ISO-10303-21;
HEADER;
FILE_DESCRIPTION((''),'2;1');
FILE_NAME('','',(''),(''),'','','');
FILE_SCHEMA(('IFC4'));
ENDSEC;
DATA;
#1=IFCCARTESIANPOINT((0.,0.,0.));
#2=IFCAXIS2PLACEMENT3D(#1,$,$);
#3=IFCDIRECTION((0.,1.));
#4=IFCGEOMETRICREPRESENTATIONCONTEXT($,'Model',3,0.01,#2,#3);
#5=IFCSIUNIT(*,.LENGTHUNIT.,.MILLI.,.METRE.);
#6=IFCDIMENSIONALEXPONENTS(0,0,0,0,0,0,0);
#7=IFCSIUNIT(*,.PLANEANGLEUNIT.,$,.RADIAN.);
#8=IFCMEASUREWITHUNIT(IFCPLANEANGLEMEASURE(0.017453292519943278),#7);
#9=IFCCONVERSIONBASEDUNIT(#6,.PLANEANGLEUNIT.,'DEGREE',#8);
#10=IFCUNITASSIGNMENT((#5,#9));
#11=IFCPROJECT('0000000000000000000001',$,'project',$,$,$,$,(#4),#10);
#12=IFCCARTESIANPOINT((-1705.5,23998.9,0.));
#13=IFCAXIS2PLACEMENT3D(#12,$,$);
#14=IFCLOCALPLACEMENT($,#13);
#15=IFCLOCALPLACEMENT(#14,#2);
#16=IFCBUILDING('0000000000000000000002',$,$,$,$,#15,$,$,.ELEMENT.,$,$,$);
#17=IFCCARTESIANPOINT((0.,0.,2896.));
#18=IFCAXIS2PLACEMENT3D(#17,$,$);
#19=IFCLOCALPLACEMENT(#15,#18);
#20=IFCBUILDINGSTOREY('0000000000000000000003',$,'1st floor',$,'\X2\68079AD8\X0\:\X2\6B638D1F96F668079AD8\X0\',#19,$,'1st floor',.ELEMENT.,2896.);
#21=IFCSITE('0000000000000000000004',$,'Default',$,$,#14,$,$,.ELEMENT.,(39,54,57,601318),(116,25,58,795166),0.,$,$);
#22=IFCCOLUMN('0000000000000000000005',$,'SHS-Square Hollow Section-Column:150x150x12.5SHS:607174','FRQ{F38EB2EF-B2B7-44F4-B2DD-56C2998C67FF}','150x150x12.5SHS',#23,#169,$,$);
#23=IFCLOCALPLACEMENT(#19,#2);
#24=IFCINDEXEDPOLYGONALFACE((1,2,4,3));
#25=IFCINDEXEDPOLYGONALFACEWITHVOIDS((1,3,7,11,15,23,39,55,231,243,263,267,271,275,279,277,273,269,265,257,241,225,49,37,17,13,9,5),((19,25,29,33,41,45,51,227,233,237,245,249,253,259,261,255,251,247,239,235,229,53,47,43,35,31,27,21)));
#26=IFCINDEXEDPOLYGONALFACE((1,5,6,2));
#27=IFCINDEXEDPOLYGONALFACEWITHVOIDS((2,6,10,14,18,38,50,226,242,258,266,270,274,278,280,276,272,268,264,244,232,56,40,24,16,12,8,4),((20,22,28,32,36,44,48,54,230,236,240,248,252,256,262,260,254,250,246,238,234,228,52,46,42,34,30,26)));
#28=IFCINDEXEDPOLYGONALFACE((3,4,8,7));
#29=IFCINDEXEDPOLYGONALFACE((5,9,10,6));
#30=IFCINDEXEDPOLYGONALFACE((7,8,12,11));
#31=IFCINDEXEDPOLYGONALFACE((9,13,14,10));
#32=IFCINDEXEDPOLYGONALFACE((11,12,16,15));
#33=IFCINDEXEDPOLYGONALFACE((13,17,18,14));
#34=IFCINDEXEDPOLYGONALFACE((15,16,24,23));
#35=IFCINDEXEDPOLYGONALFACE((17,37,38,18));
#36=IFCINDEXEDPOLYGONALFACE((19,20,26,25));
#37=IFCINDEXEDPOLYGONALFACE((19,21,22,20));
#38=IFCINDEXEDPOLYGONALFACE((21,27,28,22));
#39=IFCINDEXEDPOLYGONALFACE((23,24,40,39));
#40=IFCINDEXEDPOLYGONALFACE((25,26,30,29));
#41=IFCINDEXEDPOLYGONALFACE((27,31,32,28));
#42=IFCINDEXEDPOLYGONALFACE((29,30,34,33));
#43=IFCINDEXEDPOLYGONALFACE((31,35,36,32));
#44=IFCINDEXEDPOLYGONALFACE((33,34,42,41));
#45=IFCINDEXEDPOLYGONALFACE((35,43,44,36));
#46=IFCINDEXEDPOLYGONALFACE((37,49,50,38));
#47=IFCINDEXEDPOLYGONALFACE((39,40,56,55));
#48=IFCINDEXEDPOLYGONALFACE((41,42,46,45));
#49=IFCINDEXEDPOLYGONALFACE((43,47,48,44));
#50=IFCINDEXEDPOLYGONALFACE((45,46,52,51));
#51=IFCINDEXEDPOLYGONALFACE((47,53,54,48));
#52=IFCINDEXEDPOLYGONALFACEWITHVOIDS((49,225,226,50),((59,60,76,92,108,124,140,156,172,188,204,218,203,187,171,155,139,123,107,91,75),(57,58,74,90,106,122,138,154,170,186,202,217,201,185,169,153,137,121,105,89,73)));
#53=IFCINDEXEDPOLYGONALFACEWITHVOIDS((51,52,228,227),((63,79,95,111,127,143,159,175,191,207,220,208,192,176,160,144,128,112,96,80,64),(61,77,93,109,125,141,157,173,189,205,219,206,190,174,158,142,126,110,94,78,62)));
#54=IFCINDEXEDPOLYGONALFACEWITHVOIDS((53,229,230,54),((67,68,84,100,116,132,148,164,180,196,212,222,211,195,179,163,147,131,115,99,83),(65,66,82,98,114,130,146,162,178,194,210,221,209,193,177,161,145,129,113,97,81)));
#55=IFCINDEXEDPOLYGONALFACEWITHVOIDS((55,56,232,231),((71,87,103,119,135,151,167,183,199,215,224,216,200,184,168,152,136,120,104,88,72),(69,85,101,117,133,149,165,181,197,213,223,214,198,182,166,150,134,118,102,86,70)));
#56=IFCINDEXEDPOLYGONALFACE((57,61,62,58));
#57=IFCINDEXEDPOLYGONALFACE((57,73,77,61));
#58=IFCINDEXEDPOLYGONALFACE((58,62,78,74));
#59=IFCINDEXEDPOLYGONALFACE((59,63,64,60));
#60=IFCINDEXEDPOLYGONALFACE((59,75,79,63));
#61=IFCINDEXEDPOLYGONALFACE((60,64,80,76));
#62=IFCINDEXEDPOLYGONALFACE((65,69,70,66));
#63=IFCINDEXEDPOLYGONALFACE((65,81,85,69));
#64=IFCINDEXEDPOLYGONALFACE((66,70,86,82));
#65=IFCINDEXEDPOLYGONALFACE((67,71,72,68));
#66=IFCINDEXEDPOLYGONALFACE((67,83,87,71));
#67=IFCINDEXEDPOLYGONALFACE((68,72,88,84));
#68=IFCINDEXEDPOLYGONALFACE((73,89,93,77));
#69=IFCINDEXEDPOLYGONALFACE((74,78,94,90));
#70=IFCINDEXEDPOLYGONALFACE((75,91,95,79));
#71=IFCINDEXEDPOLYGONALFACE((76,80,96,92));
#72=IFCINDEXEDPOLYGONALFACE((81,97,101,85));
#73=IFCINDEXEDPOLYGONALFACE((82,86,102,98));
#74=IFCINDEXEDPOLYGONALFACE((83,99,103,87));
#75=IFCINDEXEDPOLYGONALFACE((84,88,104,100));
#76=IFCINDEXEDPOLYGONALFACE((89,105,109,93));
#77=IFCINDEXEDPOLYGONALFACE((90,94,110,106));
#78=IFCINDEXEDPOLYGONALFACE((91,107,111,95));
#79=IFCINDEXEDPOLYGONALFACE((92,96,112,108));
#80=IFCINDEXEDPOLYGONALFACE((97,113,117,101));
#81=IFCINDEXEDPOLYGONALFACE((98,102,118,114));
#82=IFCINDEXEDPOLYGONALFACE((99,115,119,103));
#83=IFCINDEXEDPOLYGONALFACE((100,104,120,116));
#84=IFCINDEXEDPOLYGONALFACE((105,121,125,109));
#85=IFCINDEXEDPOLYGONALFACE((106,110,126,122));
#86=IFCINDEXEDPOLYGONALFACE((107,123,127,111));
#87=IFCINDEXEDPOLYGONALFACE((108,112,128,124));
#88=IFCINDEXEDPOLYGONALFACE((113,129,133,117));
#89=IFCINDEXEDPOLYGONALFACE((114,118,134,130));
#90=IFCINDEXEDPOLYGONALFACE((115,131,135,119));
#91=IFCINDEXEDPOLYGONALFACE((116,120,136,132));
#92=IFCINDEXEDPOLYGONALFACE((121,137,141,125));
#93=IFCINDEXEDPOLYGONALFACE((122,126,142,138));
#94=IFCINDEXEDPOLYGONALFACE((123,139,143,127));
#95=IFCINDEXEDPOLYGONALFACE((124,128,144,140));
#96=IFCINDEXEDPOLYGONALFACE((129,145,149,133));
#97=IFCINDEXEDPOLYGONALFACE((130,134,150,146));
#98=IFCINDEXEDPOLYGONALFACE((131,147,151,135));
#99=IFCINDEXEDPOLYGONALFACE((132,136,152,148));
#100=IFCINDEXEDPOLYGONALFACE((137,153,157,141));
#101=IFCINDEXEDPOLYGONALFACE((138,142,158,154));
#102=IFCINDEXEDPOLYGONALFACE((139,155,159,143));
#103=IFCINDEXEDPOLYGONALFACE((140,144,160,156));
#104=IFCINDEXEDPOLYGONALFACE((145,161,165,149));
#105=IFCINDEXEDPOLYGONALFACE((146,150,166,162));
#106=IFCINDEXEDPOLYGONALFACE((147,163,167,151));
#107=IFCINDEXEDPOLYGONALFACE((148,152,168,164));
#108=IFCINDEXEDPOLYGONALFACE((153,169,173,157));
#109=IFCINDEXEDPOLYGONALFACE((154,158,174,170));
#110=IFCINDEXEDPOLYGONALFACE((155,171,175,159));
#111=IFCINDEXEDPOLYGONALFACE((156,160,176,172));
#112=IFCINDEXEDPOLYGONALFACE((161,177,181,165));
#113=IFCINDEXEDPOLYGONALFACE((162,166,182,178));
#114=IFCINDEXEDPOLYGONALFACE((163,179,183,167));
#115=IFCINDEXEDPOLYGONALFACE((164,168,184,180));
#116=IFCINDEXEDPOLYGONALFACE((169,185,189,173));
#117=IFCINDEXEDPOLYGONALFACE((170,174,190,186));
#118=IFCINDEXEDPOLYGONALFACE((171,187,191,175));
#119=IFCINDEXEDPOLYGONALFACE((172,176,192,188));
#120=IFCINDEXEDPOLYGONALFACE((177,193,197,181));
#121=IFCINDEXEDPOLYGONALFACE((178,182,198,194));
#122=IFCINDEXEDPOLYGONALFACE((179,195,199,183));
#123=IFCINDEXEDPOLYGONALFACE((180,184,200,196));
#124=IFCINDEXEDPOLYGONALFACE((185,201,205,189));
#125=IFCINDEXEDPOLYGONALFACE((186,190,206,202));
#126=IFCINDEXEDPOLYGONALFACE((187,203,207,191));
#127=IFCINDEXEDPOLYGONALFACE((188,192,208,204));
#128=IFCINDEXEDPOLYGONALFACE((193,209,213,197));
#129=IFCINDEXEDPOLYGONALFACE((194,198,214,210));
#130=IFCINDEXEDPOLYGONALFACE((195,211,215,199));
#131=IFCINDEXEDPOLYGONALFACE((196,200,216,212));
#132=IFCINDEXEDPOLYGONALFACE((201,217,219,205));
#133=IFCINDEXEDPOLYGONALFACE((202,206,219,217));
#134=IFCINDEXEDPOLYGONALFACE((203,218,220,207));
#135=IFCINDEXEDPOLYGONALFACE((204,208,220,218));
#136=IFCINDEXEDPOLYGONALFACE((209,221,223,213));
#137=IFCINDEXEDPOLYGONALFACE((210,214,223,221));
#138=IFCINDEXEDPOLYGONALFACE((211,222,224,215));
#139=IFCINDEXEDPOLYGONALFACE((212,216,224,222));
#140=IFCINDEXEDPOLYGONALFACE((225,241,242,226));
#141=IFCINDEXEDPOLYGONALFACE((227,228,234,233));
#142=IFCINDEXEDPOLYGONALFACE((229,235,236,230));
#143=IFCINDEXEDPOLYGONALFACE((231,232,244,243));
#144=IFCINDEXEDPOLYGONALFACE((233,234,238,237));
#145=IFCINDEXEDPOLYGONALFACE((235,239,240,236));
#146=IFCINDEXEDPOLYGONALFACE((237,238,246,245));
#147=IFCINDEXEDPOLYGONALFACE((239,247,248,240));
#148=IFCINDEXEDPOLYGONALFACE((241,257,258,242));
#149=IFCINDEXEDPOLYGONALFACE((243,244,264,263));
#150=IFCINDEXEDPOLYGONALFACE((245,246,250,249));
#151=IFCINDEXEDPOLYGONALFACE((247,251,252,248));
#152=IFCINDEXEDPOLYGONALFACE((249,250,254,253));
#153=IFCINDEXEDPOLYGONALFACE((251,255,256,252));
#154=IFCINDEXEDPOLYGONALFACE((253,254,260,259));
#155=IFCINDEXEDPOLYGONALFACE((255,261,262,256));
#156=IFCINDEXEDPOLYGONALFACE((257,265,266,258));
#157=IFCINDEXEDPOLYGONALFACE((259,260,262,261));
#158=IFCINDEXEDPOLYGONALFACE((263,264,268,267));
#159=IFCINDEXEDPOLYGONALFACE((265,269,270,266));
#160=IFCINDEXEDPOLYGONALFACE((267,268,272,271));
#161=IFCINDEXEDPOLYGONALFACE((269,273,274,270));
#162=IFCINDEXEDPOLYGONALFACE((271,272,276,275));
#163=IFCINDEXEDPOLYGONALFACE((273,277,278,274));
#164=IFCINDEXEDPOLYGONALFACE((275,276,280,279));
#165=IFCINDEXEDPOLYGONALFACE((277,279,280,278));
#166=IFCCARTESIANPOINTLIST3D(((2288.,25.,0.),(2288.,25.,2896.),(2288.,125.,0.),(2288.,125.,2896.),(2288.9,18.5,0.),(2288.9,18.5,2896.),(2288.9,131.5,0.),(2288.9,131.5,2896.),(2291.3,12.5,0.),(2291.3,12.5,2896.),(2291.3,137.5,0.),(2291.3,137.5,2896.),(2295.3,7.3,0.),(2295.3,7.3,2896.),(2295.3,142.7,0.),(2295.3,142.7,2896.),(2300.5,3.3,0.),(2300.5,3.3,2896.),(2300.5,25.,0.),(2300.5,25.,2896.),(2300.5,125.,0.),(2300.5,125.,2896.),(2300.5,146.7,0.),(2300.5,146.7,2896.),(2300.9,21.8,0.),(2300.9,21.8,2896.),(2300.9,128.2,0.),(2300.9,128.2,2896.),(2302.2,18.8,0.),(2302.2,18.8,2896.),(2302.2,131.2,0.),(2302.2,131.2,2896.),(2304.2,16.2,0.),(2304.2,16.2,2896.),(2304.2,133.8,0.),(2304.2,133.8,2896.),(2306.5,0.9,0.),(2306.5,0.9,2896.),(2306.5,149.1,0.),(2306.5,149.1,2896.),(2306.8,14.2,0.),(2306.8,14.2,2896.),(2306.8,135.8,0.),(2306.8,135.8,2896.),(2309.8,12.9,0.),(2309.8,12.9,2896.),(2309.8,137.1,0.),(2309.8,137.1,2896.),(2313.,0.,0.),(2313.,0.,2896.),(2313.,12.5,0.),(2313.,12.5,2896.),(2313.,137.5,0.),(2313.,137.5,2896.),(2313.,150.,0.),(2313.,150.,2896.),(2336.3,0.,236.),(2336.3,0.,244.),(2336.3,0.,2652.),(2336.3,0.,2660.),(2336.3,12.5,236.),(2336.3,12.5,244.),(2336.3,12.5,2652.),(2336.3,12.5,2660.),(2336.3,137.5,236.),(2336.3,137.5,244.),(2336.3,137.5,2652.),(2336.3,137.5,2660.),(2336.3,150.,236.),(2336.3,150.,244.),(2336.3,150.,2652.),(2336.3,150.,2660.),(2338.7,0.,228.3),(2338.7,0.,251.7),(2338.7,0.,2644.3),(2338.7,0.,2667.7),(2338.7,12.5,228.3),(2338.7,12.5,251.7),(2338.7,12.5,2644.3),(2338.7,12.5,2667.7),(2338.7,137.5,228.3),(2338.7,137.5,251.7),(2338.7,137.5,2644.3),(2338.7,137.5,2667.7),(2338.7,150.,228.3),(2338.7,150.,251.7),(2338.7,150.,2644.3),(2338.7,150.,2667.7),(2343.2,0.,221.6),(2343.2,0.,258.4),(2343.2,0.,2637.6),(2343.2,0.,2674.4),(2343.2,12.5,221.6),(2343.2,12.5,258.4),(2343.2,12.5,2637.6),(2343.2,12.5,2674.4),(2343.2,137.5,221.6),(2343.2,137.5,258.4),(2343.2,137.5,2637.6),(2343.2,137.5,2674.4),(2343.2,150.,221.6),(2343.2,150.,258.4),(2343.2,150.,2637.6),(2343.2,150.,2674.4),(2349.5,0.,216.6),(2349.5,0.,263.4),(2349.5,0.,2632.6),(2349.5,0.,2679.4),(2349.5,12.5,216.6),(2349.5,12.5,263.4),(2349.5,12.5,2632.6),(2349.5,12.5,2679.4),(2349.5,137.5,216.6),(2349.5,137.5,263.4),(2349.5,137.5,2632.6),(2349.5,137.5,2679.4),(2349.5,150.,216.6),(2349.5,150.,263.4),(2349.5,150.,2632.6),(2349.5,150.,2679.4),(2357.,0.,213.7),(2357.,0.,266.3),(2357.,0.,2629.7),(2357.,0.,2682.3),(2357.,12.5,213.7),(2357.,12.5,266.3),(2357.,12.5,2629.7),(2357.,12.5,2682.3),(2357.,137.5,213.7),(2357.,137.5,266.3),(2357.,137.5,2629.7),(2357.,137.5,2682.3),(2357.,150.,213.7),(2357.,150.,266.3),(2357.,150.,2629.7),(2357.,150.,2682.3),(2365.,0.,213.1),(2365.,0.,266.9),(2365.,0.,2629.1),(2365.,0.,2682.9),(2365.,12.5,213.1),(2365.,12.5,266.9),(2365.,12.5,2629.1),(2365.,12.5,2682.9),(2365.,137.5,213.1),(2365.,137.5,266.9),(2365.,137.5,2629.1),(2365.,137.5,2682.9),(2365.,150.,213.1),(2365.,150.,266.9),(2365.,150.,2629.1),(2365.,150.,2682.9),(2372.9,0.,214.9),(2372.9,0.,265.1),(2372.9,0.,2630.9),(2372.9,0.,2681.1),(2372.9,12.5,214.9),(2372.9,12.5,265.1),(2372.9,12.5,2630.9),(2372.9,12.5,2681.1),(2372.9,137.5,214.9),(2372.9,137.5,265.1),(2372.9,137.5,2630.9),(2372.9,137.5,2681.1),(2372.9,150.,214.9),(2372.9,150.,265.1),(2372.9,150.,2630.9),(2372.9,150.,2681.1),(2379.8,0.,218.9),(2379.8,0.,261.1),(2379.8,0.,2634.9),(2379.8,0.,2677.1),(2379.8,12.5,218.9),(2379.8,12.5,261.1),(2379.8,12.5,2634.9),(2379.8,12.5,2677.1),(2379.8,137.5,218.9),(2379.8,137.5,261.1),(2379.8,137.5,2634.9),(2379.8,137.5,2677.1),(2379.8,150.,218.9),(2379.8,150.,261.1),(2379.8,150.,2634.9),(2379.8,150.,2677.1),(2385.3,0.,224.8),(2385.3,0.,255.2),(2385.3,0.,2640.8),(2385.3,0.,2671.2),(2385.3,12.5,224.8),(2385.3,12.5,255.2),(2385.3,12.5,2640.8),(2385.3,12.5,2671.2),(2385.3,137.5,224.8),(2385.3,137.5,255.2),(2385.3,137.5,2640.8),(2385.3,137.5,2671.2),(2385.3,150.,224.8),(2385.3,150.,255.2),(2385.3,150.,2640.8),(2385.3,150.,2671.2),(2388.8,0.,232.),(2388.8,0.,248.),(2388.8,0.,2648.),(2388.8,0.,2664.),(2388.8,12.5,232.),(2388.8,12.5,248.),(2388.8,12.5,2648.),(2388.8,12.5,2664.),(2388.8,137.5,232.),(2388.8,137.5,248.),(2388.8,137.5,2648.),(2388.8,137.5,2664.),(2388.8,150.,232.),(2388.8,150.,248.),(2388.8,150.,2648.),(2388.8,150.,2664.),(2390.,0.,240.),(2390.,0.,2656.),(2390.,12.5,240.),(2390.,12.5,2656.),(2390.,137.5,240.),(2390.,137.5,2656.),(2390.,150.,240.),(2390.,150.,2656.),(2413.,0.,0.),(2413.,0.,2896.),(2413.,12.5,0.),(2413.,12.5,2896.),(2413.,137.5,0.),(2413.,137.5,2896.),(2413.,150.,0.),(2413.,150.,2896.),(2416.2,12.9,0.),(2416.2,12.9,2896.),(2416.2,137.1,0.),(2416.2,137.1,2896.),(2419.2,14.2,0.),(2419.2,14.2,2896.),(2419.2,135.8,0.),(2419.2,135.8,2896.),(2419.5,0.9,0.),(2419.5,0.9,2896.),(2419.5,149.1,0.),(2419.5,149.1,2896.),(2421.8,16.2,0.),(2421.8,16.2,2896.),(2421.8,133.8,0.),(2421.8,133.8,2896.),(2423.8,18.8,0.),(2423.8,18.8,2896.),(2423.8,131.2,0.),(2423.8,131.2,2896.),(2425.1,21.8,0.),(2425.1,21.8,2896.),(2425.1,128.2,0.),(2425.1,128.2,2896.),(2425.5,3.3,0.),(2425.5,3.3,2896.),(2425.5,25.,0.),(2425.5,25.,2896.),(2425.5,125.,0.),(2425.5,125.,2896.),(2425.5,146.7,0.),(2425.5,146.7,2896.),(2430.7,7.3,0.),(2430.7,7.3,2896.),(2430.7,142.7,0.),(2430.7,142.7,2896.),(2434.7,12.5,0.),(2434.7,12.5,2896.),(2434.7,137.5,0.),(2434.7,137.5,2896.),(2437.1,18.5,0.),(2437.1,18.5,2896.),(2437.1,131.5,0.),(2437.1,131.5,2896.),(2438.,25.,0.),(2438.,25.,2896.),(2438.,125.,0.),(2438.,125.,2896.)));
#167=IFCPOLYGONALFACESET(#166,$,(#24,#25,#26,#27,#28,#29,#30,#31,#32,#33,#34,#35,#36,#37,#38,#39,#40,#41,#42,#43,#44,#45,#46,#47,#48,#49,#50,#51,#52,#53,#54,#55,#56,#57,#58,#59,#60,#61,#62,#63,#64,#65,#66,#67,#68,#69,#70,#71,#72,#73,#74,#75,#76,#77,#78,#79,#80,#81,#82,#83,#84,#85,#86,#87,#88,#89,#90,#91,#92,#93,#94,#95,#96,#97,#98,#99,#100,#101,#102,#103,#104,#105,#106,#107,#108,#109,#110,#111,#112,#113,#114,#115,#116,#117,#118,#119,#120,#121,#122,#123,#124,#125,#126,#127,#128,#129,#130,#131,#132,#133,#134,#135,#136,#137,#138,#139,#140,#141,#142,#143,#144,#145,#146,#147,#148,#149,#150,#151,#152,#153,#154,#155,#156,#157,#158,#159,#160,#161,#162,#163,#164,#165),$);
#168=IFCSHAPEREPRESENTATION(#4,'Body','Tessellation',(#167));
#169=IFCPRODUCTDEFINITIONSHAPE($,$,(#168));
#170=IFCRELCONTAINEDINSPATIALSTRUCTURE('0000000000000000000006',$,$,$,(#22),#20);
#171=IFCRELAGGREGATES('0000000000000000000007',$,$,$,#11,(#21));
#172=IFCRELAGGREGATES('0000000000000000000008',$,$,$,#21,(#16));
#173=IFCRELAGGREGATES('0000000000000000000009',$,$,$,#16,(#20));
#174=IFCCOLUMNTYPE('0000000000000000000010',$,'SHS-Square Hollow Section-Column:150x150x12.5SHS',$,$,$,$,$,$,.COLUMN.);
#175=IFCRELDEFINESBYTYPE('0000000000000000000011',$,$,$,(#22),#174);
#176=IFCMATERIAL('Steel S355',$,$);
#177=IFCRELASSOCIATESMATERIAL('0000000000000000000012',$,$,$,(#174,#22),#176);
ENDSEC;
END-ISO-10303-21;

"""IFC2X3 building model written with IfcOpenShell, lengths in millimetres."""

from ifc_helpers import new_model, entity, si_unit, converted_unit, direction, frame, frame_2d, origin, origin_2d, place, context, project, spatial, circle_curve, hollow_rectangle, outline, extrude, material, type_object, element, save


model = new_model("IFC2X3")

# Units and contexts
model_context = context("Model", 3, precision=0.01, world=origin(), true_north=direction((0.0, 1.0)))
ifc_project = project(units=[si_unit("LENGTHUNIT", "METRE", prefix="MILLI"), converted_unit("PLANEANGLEUNIT", "DEGREE", entity("IfcPlaneAngleMeasure", 0.017453292519943278), si_unit("PLANEANGLEUNIT", "RADIAN"), dimensions=[0, 0, 0, 0, 0, 0, 0])], contexts=[model_context])

# Site, building, storey
site_placement = place(None, frame((-1705.5, 23998.9, 0.0)))
site = spatial("IfcSite", under=ifc_project, at=site_placement, Name="Default", CompositionType="ELEMENT", RefLatitude=(39, 54, 57, 601318), RefLongitude=(116, 25, 58, 795166), RefElevation=0.0)
building_placement = place(site_placement, origin())
building = spatial("IfcBuilding", under=site, at=building_placement, CompositionType="ELEMENT")
storey_placement = place(building_placement, frame((0.0, 0.0, 2896.0)))
storey = spatial("IfcBuildingStorey", under=building, at=storey_placement, Name="1st floor", ObjectType="标高:正负零标高", LongName="1st floor", CompositionType="ELEMENT", Elevation=2896.0)

# Shared definitions
ifc_material_1 = material(Name="Steel S355")

# Column, openings
column_type_1 = type_object("IfcColumnType", Name="SHS-Square Hollow Section-Column:150x150x12.5SHS", PredefinedType="COLUMN", material=ifc_material_1)
column_1_placement = place(storey_placement, frame((2363.0, 75.0, 2896.0), z_axis=(0.0, 0.0, 1.0), x_axis=(0.0, -1.0, 0.0)))
column_1 = element("IfcColumn", 1, at=column_1_placement, inside=storey, type_object=column_type_1, material=ifc_material_1, Name="SHS-Square Hollow Section-Column:150x150x12.5SHS:607174", Description="FRQ{F38EB2EF-B2B7-44F4-B2DD-56C2998C67FF}", ObjectType="150x150x12.5SHS", context=model_context, shape_type="SweptSolid", body=[
    extrude(hollow_rectangle(XDim=150.0, YDim=150.0, WallThickness=12.5, InnerFilletRadius=12.5, OuterFilletRadius=25.0, at=origin_2d()), origin(), (0.0, 0.0, -1.0), 2896.0),
])
opening_1_placement = place(column_1_placement, frame((-175.1, 0.0, 0.0), z_axis=(1.0, 0.0, 0.0), x_axis=(0.0, 1.0, 0.0)))
element("IfcOpeningElement", 2, at=opening_1_placement, cuts=column_1, ObjectType="Opening", context=model_context, shape_type="SweptSolid", body=[
    extrude(outline(circle_curve(frame_2d((0.0, -240.0), x_axis=(1.0, 0.0)), 27.0)), origin(), (0.0, 0.0, 1.0), 350.2),
])
opening_2_placement = place(column_1_placement, frame((-175.1, 0.0, -2896.0), z_axis=(1.0, 0.0, 0.0), x_axis=(0.0, 1.0, 0.0)))
element("IfcOpeningElement", 3, at=opening_2_placement, cuts=column_1, ObjectType="Opening", context=model_context, shape_type="SweptSolid", body=[
    extrude(outline(circle_curve(frame_2d((0.0, 240.0), x_axis=(1.0, 0.0)), 27.0)), origin(), (0.0, 0.0, 1.0), 350.2),
])

save(model, "model.ifc")
